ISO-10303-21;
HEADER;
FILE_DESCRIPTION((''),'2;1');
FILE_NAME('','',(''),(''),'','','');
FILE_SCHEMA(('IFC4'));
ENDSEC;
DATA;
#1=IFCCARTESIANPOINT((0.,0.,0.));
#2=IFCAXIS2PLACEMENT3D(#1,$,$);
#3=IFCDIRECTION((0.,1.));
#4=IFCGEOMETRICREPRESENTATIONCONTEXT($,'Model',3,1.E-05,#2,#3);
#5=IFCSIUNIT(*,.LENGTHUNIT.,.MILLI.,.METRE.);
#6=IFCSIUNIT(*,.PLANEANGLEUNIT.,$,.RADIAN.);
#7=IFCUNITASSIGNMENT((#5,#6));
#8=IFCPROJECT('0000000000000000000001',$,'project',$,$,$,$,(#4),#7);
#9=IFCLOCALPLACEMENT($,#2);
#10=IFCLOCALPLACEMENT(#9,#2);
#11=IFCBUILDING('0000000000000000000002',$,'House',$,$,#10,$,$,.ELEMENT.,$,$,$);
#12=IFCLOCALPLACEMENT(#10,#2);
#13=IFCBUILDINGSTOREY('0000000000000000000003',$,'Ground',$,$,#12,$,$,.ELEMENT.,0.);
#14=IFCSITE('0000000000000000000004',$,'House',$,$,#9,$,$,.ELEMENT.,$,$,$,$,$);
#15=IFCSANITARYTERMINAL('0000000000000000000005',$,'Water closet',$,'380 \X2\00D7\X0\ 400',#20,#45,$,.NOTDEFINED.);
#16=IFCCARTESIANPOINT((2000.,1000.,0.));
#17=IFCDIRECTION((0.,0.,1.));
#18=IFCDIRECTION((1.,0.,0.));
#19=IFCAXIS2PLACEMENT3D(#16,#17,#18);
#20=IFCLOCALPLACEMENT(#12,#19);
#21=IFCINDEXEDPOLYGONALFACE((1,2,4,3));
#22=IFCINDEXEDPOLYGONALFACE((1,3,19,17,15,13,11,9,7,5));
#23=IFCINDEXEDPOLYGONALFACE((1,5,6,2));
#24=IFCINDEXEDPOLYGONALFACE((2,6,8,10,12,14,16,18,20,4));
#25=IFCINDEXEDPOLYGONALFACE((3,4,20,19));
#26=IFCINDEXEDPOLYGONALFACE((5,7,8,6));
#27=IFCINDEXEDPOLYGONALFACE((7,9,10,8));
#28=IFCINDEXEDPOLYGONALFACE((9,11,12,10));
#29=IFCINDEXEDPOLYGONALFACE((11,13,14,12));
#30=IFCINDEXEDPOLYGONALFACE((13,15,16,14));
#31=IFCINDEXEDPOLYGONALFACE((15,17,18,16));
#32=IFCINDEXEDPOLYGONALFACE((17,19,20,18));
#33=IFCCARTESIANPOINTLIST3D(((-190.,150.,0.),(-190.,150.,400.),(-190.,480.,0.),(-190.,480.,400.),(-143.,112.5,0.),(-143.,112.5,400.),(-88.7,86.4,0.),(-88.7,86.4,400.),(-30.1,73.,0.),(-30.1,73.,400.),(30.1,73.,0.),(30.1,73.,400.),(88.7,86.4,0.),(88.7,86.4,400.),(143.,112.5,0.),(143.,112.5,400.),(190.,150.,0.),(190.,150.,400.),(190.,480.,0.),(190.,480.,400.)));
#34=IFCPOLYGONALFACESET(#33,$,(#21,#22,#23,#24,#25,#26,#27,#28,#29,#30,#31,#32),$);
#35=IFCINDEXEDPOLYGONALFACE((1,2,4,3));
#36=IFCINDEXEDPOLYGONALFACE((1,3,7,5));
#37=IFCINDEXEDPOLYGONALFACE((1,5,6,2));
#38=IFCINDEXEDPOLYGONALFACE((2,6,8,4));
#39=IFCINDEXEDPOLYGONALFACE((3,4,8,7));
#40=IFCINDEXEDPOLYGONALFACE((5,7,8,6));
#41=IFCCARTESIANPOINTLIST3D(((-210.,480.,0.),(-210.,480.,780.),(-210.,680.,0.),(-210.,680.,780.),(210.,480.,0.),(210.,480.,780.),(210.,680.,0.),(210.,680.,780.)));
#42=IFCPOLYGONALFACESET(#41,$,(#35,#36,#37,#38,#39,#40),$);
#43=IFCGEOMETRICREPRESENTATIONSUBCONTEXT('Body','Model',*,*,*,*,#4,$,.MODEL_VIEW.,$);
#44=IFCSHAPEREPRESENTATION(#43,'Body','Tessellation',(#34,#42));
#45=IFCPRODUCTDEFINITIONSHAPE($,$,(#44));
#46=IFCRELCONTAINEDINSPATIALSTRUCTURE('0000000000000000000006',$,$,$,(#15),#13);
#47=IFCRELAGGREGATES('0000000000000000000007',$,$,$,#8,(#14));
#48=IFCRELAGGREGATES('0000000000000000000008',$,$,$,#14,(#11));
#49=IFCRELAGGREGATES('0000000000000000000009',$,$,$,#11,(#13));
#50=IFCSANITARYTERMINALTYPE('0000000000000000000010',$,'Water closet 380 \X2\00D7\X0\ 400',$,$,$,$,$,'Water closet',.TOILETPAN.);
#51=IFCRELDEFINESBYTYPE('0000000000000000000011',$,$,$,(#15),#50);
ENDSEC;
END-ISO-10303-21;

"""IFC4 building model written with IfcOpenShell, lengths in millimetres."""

from ifc_helpers import new_model, si_unit, direction, frame, origin, origin_with_axes, place, context, subcontext, project, spatial, polyline, line, arc, indexed_curve, outline, extrude, source, transform, mapped, type_object, type_shapes, element, save


model = new_model("IFC4")

# Units and contexts
model_context = context("Model", 3, precision=1e-05, world=origin(), true_north=direction((0.0, 1.0)))
body_context = subcontext(model_context, "Body", "Model", "MODEL_VIEW")
ifc_project = project(units=[si_unit("LENGTHUNIT", "METRE", prefix="MILLI"), si_unit("PLANEANGLEUNIT", "RADIAN")], contexts=[model_context])

# Site, building, storey
site_placement = place(None, origin())
site = spatial("IfcSite", under=ifc_project, at=site_placement, Name="House", CompositionType="ELEMENT")
building_placement = place(site_placement, origin())
building = spatial("IfcBuilding", under=site, at=building_placement, Name="House", CompositionType="ELEMENT")
storey_placement = place(building_placement, origin())
storey = spatial("IfcBuildingStorey", under=building, at=storey_placement, Name="Ground", CompositionType="ELEMENT", Elevation=0.0)

# Sanitary terminal
sanitary_terminal_type_1 = type_object("IfcSanitaryTerminalType", Name="Water closet 380 × 400", ElementType="Water closet", PredefinedType="TOILETPAN")
shared_shape_1 = source(origin(), body_context, "Body", "SweptSolid", [
    extrude(outline(indexed_curve([(-190.0, 480.0), (-190.0, 150.0), (0.0, 71.3), (190.0, 150.0), (190.0, 480.0)], segments=[line(1, 2), arc(2, 3, 4), line(4, 5), line(5, 1)], self_intersect=False)), origin_with_axes(), (0.0, 0.0, 1.0), 400.0),
    extrude(outline(polyline([(-210.0, 480.0), (210.0, 480.0), (210.0, 680.0), (-210.0, 680.0), (-210.0, 480.0)])), origin(), (0.0, 0.0, 1.0), 780.0),
])
type_shapes(sanitary_terminal_type_1, [shared_shape_1])
sanitary_terminal_1_placement = place(storey_placement, frame((2000.0, 1000.0, 0.0), z_axis=(0.0, 0.0, 1.0), x_axis=(1.0, 0.0, 0.0)))
element("IfcSanitaryTerminal", 1, at=sanitary_terminal_1_placement, inside=storey, type_object=sanitary_terminal_type_1, Name="Water closet", ObjectType="380 × 400", PredefinedType="NOTDEFINED", context=body_context, shape_type="MappedRepresentation", body=[
    mapped(shared_shape_1, transform((0.0, 0.0, 0.0))),
])

save(model, "model.ifc")
